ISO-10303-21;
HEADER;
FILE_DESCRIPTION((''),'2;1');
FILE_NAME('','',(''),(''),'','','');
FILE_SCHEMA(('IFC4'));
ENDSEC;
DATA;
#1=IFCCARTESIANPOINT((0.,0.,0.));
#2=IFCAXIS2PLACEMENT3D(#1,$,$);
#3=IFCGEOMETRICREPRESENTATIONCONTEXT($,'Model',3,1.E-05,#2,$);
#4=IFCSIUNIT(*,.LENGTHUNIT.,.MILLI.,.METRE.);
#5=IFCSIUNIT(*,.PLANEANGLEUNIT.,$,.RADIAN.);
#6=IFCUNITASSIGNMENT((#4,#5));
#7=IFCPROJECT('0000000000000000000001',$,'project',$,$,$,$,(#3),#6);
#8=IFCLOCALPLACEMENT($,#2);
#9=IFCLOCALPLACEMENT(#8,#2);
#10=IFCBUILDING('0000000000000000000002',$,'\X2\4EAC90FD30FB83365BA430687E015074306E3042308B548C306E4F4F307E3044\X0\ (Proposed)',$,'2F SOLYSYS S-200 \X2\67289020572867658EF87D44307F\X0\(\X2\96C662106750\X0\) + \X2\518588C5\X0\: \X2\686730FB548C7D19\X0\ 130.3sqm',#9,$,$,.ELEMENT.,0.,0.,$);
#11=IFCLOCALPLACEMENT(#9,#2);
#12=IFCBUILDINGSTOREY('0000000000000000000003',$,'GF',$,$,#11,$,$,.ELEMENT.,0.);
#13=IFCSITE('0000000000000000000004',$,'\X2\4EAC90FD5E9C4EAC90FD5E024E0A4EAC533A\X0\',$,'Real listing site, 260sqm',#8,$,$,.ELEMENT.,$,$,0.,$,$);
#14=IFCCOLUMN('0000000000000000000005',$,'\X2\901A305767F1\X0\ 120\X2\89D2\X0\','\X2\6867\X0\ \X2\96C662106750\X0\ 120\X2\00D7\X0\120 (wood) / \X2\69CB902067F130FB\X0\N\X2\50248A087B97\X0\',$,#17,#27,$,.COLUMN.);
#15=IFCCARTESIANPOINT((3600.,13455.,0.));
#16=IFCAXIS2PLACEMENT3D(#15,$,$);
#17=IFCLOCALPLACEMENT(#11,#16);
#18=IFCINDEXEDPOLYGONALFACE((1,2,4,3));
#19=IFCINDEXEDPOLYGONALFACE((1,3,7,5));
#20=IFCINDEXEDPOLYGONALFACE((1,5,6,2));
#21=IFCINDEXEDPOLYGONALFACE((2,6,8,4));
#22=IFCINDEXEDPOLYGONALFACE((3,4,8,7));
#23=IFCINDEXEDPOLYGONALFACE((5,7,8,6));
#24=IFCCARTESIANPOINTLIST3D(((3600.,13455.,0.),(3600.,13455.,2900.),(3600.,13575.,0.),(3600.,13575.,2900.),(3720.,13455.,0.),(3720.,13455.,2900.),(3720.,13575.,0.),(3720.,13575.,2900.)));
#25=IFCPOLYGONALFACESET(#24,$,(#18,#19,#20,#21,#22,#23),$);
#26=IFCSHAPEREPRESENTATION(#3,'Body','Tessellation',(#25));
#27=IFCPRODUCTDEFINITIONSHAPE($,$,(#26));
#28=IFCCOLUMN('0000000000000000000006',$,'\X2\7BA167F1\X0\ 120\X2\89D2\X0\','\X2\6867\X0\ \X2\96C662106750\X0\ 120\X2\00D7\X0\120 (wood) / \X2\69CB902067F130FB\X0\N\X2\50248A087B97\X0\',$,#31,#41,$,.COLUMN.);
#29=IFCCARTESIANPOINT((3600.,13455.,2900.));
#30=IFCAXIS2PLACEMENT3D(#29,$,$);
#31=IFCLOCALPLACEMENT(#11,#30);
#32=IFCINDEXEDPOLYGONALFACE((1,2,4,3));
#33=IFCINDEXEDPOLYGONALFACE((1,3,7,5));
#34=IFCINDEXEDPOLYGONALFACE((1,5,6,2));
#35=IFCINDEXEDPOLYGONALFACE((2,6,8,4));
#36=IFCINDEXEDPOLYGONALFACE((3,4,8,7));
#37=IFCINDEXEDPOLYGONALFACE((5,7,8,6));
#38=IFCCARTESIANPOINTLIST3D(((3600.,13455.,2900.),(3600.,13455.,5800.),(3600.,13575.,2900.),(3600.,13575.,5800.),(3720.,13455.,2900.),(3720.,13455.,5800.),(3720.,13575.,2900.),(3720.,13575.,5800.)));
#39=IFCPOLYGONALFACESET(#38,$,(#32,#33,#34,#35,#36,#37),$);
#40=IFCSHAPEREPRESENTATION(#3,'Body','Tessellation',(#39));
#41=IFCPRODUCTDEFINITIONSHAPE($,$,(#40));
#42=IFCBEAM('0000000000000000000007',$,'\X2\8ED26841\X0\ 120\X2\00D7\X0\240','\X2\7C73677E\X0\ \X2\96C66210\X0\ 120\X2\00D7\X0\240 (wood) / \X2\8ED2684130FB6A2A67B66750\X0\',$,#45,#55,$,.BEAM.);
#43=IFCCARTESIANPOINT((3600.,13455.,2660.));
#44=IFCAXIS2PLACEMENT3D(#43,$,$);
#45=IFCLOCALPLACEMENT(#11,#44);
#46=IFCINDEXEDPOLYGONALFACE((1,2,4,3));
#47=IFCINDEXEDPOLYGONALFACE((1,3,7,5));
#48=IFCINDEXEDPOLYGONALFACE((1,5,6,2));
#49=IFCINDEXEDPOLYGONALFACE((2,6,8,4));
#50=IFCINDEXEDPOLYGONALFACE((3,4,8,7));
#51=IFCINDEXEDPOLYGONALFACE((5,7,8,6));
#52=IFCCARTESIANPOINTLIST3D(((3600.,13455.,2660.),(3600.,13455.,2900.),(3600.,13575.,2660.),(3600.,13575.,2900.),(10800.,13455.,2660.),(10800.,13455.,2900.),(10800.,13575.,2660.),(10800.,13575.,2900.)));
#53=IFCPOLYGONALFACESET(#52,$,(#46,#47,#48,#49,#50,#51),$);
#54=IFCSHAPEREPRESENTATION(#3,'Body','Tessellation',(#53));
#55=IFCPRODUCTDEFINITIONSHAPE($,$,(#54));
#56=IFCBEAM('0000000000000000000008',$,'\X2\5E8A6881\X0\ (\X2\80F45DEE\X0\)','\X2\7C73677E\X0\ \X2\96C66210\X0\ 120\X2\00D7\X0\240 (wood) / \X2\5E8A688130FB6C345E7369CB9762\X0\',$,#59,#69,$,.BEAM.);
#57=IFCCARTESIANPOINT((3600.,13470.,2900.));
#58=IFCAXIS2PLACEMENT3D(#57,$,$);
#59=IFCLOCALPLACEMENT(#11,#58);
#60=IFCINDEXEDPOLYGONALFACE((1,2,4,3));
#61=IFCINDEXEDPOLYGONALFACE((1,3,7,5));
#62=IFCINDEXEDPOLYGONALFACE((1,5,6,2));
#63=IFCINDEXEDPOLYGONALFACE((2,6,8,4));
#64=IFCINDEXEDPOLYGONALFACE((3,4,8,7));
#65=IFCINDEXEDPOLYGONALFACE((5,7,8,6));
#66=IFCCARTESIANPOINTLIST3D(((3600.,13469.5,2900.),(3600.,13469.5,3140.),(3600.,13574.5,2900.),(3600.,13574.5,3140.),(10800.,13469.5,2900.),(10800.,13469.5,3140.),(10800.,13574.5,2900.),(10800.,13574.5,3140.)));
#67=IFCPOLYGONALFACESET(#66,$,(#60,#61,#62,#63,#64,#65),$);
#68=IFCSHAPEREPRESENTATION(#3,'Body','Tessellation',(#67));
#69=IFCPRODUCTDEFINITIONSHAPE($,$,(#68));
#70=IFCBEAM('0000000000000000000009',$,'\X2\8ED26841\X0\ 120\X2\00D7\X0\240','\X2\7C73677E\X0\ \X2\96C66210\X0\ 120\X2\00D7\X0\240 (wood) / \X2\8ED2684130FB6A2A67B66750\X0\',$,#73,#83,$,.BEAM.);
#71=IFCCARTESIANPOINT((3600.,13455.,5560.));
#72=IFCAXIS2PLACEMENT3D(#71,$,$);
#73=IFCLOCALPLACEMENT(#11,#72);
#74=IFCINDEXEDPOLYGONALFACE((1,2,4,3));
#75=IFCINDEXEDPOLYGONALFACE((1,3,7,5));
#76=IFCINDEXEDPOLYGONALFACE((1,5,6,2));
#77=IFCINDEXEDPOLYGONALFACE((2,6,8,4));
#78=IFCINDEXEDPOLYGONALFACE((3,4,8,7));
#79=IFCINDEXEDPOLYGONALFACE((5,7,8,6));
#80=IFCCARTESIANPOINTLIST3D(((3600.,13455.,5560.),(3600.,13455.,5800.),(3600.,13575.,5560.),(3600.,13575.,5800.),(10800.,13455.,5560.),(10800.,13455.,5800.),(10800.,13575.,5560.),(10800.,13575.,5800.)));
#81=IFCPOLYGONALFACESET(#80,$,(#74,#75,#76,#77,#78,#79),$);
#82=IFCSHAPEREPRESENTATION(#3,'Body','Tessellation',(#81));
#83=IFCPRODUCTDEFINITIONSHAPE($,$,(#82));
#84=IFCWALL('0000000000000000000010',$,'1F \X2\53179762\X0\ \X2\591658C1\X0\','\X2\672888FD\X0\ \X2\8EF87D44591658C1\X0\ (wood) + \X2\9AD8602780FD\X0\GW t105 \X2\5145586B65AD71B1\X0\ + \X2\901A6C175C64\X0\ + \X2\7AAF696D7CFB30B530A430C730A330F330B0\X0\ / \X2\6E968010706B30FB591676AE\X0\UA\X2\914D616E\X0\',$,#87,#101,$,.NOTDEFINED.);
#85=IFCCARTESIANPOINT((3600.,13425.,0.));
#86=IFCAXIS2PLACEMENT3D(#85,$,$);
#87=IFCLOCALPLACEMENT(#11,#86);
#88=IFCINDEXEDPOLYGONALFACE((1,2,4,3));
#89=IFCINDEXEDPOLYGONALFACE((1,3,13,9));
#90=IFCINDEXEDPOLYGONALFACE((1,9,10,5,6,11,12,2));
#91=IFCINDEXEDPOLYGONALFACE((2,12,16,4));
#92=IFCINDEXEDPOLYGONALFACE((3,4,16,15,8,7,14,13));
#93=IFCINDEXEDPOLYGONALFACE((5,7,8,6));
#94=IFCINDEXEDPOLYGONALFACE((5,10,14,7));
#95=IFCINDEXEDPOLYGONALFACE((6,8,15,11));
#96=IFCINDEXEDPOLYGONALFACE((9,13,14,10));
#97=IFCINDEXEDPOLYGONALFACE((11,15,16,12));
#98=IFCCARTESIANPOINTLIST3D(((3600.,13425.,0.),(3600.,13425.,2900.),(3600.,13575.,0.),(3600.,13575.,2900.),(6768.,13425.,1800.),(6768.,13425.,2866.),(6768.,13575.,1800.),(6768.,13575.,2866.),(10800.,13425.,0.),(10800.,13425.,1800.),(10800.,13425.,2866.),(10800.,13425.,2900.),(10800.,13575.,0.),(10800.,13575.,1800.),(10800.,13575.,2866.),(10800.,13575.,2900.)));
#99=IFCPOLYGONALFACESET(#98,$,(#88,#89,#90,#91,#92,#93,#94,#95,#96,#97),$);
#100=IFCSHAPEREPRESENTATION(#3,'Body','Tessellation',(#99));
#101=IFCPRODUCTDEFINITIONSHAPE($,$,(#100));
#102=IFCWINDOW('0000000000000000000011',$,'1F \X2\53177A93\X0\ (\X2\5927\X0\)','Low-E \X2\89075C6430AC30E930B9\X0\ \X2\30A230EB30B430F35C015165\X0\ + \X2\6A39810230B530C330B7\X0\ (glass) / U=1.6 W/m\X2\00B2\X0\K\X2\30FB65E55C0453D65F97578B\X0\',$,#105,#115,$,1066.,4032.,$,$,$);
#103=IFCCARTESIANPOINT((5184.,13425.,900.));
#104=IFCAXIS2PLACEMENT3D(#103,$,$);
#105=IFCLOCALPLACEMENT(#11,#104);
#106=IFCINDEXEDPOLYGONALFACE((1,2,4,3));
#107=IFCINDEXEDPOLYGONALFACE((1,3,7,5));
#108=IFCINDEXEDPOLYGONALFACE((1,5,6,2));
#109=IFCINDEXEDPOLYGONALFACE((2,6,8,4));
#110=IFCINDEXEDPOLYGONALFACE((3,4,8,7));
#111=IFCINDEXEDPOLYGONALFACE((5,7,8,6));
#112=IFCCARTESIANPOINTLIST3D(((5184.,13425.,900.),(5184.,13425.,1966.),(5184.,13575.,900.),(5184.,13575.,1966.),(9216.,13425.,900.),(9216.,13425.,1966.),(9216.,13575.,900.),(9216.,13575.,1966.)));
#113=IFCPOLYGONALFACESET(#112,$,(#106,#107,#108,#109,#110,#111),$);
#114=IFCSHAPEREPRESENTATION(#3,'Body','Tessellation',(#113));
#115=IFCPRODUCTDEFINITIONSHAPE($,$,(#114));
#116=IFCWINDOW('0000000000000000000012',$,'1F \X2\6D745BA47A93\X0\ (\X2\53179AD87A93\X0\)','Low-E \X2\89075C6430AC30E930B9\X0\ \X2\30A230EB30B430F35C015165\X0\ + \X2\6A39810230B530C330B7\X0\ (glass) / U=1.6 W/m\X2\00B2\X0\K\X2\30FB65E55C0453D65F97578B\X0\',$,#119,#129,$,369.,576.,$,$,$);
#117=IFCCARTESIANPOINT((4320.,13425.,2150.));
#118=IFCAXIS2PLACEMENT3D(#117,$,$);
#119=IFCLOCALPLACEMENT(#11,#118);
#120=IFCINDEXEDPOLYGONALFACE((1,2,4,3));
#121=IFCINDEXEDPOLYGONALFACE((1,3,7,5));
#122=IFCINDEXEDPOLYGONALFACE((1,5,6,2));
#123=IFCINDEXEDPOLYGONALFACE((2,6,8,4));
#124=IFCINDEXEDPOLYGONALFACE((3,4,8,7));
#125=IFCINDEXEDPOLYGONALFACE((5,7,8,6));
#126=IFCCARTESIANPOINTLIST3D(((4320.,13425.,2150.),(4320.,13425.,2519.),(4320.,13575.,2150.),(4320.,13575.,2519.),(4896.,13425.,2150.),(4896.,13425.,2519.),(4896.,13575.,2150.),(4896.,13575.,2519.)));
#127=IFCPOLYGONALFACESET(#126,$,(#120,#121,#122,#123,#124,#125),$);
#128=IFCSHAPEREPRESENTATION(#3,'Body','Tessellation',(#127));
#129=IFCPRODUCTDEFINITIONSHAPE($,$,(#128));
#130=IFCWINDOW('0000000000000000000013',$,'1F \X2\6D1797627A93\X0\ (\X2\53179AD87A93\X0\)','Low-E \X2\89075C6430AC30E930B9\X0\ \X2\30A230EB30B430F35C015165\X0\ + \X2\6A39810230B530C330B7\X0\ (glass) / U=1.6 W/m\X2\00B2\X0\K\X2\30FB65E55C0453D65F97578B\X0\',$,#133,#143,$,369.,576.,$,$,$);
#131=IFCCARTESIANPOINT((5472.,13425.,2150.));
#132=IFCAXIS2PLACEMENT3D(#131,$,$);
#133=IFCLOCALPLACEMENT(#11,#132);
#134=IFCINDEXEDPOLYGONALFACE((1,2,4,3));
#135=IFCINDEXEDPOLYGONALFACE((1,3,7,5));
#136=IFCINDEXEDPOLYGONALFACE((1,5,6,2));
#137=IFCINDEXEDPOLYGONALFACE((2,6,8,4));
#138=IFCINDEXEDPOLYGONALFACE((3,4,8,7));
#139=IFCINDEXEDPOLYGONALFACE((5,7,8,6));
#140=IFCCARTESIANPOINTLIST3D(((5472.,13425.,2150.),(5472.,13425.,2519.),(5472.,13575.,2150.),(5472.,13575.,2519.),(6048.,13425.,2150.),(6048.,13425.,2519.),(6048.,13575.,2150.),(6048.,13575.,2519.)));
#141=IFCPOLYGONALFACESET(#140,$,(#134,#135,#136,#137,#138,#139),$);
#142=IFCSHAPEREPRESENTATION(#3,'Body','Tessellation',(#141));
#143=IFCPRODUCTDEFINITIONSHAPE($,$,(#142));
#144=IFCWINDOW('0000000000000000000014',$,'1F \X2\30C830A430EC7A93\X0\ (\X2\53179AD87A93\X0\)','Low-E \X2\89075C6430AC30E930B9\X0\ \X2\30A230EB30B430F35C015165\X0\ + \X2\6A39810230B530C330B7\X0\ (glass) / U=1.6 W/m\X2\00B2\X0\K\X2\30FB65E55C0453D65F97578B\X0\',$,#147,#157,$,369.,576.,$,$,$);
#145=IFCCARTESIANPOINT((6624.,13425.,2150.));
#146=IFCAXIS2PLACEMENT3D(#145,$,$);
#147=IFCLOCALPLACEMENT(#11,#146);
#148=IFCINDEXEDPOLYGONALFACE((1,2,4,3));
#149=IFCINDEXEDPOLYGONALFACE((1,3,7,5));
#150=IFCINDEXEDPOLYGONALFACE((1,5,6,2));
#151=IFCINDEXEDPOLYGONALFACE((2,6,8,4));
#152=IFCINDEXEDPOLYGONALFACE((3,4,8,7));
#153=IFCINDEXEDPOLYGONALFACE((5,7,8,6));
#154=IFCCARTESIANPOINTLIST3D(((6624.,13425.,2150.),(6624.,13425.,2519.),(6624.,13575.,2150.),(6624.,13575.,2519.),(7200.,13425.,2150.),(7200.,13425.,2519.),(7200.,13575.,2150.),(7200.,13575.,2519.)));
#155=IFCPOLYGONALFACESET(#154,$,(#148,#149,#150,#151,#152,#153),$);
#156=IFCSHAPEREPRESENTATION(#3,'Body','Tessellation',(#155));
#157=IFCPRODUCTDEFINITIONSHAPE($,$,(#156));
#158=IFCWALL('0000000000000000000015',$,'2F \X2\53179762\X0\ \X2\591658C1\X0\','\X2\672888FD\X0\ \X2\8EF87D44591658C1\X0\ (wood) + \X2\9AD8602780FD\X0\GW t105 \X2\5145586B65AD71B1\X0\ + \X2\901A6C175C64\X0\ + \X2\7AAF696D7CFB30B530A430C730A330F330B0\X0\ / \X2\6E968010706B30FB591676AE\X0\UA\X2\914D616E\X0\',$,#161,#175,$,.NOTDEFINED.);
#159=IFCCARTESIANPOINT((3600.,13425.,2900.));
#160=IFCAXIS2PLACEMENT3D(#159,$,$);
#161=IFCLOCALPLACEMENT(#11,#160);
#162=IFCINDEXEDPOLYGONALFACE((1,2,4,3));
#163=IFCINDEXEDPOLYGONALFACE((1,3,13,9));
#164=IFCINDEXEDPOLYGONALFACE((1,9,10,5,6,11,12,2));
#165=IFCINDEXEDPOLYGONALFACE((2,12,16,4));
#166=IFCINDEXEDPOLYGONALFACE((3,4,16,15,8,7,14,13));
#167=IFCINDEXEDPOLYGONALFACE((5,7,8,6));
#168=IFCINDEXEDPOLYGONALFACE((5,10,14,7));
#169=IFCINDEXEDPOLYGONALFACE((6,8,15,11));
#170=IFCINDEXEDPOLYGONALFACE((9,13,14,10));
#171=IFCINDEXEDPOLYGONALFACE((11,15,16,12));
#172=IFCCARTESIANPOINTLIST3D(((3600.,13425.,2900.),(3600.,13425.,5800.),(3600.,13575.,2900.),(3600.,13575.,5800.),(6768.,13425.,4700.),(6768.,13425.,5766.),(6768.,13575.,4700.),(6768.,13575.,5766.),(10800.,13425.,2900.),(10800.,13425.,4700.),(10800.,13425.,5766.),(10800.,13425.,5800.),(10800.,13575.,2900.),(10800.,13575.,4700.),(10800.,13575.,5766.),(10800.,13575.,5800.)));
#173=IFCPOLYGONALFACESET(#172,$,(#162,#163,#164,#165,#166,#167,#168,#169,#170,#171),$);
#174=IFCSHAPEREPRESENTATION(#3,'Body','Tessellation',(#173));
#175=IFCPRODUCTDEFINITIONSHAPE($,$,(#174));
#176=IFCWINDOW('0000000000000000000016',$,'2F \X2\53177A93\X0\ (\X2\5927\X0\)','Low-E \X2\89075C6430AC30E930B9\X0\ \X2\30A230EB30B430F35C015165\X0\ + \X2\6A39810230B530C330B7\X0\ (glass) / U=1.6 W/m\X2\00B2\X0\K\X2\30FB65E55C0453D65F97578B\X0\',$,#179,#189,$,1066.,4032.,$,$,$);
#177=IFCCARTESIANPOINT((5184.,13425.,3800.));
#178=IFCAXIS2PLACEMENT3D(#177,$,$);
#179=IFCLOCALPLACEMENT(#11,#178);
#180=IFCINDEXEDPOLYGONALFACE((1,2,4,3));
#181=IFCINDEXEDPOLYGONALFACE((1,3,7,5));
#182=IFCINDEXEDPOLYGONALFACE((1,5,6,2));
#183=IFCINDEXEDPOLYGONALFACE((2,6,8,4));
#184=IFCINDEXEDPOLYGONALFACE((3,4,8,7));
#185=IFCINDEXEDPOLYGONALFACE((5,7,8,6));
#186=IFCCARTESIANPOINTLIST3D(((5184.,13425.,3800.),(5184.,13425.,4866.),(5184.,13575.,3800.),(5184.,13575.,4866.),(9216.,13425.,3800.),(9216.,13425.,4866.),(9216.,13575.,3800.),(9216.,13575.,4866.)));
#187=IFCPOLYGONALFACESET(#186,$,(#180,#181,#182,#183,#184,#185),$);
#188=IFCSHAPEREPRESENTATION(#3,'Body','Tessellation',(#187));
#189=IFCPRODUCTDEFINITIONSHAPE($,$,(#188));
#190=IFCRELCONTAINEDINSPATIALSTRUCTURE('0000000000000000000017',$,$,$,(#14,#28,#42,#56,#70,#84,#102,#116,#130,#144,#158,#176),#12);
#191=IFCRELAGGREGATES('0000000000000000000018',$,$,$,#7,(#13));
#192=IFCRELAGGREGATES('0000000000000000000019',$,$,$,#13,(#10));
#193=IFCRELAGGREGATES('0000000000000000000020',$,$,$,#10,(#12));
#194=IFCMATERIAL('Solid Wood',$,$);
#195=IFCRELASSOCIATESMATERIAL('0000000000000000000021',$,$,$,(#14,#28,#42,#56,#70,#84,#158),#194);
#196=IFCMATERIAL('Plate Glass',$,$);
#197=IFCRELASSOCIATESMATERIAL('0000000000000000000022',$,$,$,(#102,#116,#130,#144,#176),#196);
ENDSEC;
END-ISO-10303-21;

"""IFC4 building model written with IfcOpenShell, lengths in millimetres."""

from ifc_helpers import new_model, si_unit, frame, frame_2d, origin, place, context, project, spatial, rectangle, extrude, material, element, fill, save


model = new_model("IFC4")

# Units and contexts
model_context = context("Model", 3, precision=1e-05, world=origin())
ifc_project = project(units=[si_unit("LENGTHUNIT", "METRE", prefix="MILLI"), si_unit("PLANEANGLEUNIT", "RADIAN")], contexts=[model_context])

# Site, building, storey
site_placement = place(None, origin())
site = spatial("IfcSite", under=ifc_project, at=site_placement, Name="京都府京都市上京区", ObjectType="Real listing site, 260sqm", CompositionType="ELEMENT", RefElevation=0.0)
building_placement = place(site_placement, origin())
building = spatial("IfcBuilding", under=site, at=building_placement, Name="京都・茶室と縁側のある和の住まい (Proposed)", ObjectType="2F SOLYSYS S-200 木造在来軸組み(集成材) + 内装: 桧・和紙 130.3sqm", CompositionType="ELEMENT", ElevationOfRefHeight=0.0, ElevationOfTerrain=0.0)
storey_placement = place(building_placement, origin())
storey = spatial("IfcBuildingStorey", under=building, at=storey_placement, Name="GF", CompositionType="ELEMENT", Elevation=0.0)

# Columns
ifc_material_1 = material(Name="Solid Wood")
column_1_placement = place(storey_placement, frame((3600.0, 13455.0, 0.0)))
element("IfcColumn", 1, at=column_1_placement, inside=storey, material=ifc_material_1, Name="通し柱 120角", Description="桧 集成材 120×120 (wood) / 構造柱・N値計算", PredefinedType="COLUMN", context=model_context, shape_type="SweptSolid", body=[
    extrude(rectangle(XDim=120.0, YDim=120.0, at=frame_2d((60.0, 60.0))), frame((3600.0, 13455.0, 0.0)), (0.0, 0.0, 1.0), 2900.0),
])
column_2_placement = place(storey_placement, frame((3600.0, 13455.0, 2900.0)))
element("IfcColumn", 2, at=column_2_placement, inside=storey, material=ifc_material_1, Name="管柱 120角", Description="桧 集成材 120×120 (wood) / 構造柱・N値計算", PredefinedType="COLUMN", context=model_context, shape_type="SweptSolid", body=[
    extrude(rectangle(XDim=120.0, YDim=120.0, at=frame_2d((60.0, 60.0))), frame((3600.0, 13455.0, 2900.0)), (0.0, 0.0, 1.0), 2900.0),
])

# Beams
beam_1_placement = place(storey_placement, frame((3600.0, 13455.0, 2660.0)))
element("IfcBeam", 3, at=beam_1_placement, inside=storey, material=ifc_material_1, Name="軒桁 120×240", Description="米松 集成 120×240 (wood) / 軒桁・横架材", PredefinedType="BEAM", context=model_context, shape_type="SweptSolid", body=[
    extrude(rectangle(XDim=7200.0, YDim=120.0, at=frame_2d((3600.0, 60.0))), frame((3600.0, 13455.0, 2660.0)), (0.0, 0.0, 1.0), 240.0),
])
beam_2_placement = place(storey_placement, frame((3600.0, 13470.0, 2900.0)))
element("IfcBeam", 4, at=beam_2_placement, inside=storey, material=ifc_material_1, Name="床梁 (胴差)", Description="米松 集成 120×240 (wood) / 床梁・水平構面", PredefinedType="BEAM", context=model_context, shape_type="SweptSolid", body=[
    extrude(rectangle(XDim=7200.0, YDim=105.0, at=frame_2d((3600.0, 52.0))), frame((3600.0, 13470.0, 2900.0)), (0.0, 0.0, 1.0), 240.0),
])
beam_3_placement = place(storey_placement, frame((3600.0, 13455.0, 5560.0)))
element("IfcBeam", 5, at=beam_3_placement, inside=storey, material=ifc_material_1, Name="軒桁 120×240", Description="米松 集成 120×240 (wood) / 軒桁・横架材", PredefinedType="BEAM", context=model_context, shape_type="SweptSolid", body=[
    extrude(rectangle(XDim=7200.0, YDim=120.0, at=frame_2d((3600.0, 60.0))), frame((3600.0, 13455.0, 5560.0)), (0.0, 0.0, 1.0), 240.0),
])

# Wall, openings, windows
wall_1_placement = place(storey_placement, frame((3600.0, 13425.0, 0.0)))
wall_1 = element("IfcWall", 6, at=wall_1_placement, inside=storey, material=ifc_material_1, Name="1F 北面 外壁", Description="木製 軸組外壁 (wood) + 高性能GW t105 充填断熱 + 通気層 + 窯業系サイディング / 準耐火・外皮UA配慮", PredefinedType="NOTDEFINED", context=model_context, shape_type="SweptSolid", body=[
    extrude(rectangle(XDim=7200.0, YDim=150.0, at=frame_2d((3600.0, 75.0))), frame((3600.0, 13425.0, 0.0)), (0.0, 0.0, 1.0), 2900.0),
])
opening_1_placement = place(storey_placement, frame((5184.0, 13425.0, 900.0)))
opening_1 = element("IfcOpeningElement", 7, at=opening_1_placement, cuts=wall_1, PredefinedType="NOTDEFINED", context=model_context, shape_type="SweptSolid", body=[
    extrude(rectangle(XDim=4032.0, YDim=150.0, at=frame_2d((2016.0, 75.0))), frame((5184.0, 13425.0, 900.0)), (0.0, 0.0, 1.0), 1066.0),
])
opening_2_placement = place(storey_placement, frame((4320.0, 13425.0, 2150.0)))
opening_2 = element("IfcOpeningElement", 8, at=opening_2_placement, cuts=wall_1, PredefinedType="NOTDEFINED", context=model_context, shape_type="SweptSolid", body=[
    extrude(rectangle(XDim=576.0, YDim=150.0, at=frame_2d((288.0, 75.0))), frame((4320.0, 13425.0, 2150.0)), (0.0, 0.0, 1.0), 369.0),
])
opening_3_placement = place(storey_placement, frame((5472.0, 13425.0, 2150.0)))
opening_3 = element("IfcOpeningElement", 9, at=opening_3_placement, cuts=wall_1, PredefinedType="NOTDEFINED", context=model_context, shape_type="SweptSolid", body=[
    extrude(rectangle(XDim=576.0, YDim=150.0, at=frame_2d((288.0, 75.0))), frame((5472.0, 13425.0, 2150.0)), (0.0, 0.0, 1.0), 369.0),
])
opening_4_placement = place(storey_placement, frame((6624.0, 13425.0, 2150.0)))
opening_4 = element("IfcOpeningElement", 10, at=opening_4_placement, cuts=wall_1, PredefinedType="NOTDEFINED", context=model_context, shape_type="SweptSolid", body=[
    extrude(rectangle(XDim=576.0, YDim=150.0, at=frame_2d((288.0, 75.0))), frame((6624.0, 13425.0, 2150.0)), (0.0, 0.0, 1.0), 369.0),
])
ifc_material_2 = material(Name="Plate Glass")
window_1_placement = place(storey_placement, frame((5184.0, 13425.0, 900.0)))
window_1 = element("IfcWindow", 11, at=window_1_placement, inside=storey, material=ifc_material_2, Name="1F 北窓 (大)", Description="Low-E 複層ガラス アルゴン封入 + 樹脂サッシ (glass) / U=1.6 W/m²K・日射取得型", OverallHeight=1066.0, OverallWidth=4032.0, context=model_context, shape_type="SweptSolid", body=[
    extrude(rectangle(XDim=4032.0, YDim=150.0, at=frame_2d((2016.0, 75.0))), frame((5184.0, 13425.0, 900.0)), (0.0, 0.0, 1.0), 1066.0),
])
fill(opening_1, window_1)
window_2_placement = place(storey_placement, frame((4320.0, 13425.0, 2150.0)))
window_2 = element("IfcWindow", 12, at=window_2_placement, inside=storey, material=ifc_material_2, Name="1F 浴室窓 (北高窓)", Description="Low-E 複層ガラス アルゴン封入 + 樹脂サッシ (glass) / U=1.6 W/m²K・日射取得型", OverallHeight=369.0, OverallWidth=576.0, context=model_context, shape_type="SweptSolid", body=[
    extrude(rectangle(XDim=576.0, YDim=150.0, at=frame_2d((288.0, 75.0))), frame((4320.0, 13425.0, 2150.0)), (0.0, 0.0, 1.0), 369.0),
])
fill(opening_2, window_2)
window_3_placement = place(storey_placement, frame((5472.0, 13425.0, 2150.0)))
window_3 = element("IfcWindow", 13, at=window_3_placement, inside=storey, material=ifc_material_2, Name="1F 洗面窓 (北高窓)", Description="Low-E 複層ガラス アルゴン封入 + 樹脂サッシ (glass) / U=1.6 W/m²K・日射取得型", OverallHeight=369.0, OverallWidth=576.0, context=model_context, shape_type="SweptSolid", body=[
    extrude(rectangle(XDim=576.0, YDim=150.0, at=frame_2d((288.0, 75.0))), frame((5472.0, 13425.0, 2150.0)), (0.0, 0.0, 1.0), 369.0),
])
fill(opening_3, window_3)
window_4_placement = place(storey_placement, frame((6624.0, 13425.0, 2150.0)))
window_4 = element("IfcWindow", 14, at=window_4_placement, inside=storey, material=ifc_material_2, Name="1F トイレ窓 (北高窓)", Description="Low-E 複層ガラス アルゴン封入 + 樹脂サッシ (glass) / U=1.6 W/m²K・日射取得型", OverallHeight=369.0, OverallWidth=576.0, context=model_context, shape_type="SweptSolid", body=[
    extrude(rectangle(XDim=576.0, YDim=150.0, at=frame_2d((288.0, 75.0))), frame((6624.0, 13425.0, 2150.0)), (0.0, 0.0, 1.0), 369.0),
])
fill(opening_4, window_4)

# Wall, opening, window
wall_2_placement = place(storey_placement, frame((3600.0, 13425.0, 2900.0)))
wall_2 = element("IfcWall", 15, at=wall_2_placement, inside=storey, material=ifc_material_1, Name="2F 北面 外壁", Description="木製 軸組外壁 (wood) + 高性能GW t105 充填断熱 + 通気層 + 窯業系サイディング / 準耐火・外皮UA配慮", PredefinedType="NOTDEFINED", context=model_context, shape_type="SweptSolid", body=[
    extrude(rectangle(XDim=7200.0, YDim=150.0, at=frame_2d((3600.0, 75.0))), frame((3600.0, 13425.0, 2900.0)), (0.0, 0.0, 1.0), 2900.0),
])
opening_5_placement = place(storey_placement, frame((5184.0, 13425.0, 3800.0)))
opening_5 = element("IfcOpeningElement", 16, at=opening_5_placement, cuts=wall_2, PredefinedType="NOTDEFINED", context=model_context, shape_type="SweptSolid", body=[
    extrude(rectangle(XDim=4032.0, YDim=150.0, at=frame_2d((2016.0, 75.0))), frame((5184.0, 13425.0, 3800.0)), (0.0, 0.0, 1.0), 1066.0),
])
window_5_placement = place(storey_placement, frame((5184.0, 13425.0, 3800.0)))
window_5 = element("IfcWindow", 17, at=window_5_placement, inside=storey, material=ifc_material_2, Name="2F 北窓 (大)", Description="Low-E 複層ガラス アルゴン封入 + 樹脂サッシ (glass) / U=1.6 W/m²K・日射取得型", OverallHeight=1066.0, OverallWidth=4032.0, context=model_context, shape_type="SweptSolid", body=[
    extrude(rectangle(XDim=4032.0, YDim=150.0, at=frame_2d((2016.0, 75.0))), frame((5184.0, 13425.0, 3800.0)), (0.0, 0.0, 1.0), 1066.0),
])
fill(opening_5, window_5)

save(model, "model.ifc")
